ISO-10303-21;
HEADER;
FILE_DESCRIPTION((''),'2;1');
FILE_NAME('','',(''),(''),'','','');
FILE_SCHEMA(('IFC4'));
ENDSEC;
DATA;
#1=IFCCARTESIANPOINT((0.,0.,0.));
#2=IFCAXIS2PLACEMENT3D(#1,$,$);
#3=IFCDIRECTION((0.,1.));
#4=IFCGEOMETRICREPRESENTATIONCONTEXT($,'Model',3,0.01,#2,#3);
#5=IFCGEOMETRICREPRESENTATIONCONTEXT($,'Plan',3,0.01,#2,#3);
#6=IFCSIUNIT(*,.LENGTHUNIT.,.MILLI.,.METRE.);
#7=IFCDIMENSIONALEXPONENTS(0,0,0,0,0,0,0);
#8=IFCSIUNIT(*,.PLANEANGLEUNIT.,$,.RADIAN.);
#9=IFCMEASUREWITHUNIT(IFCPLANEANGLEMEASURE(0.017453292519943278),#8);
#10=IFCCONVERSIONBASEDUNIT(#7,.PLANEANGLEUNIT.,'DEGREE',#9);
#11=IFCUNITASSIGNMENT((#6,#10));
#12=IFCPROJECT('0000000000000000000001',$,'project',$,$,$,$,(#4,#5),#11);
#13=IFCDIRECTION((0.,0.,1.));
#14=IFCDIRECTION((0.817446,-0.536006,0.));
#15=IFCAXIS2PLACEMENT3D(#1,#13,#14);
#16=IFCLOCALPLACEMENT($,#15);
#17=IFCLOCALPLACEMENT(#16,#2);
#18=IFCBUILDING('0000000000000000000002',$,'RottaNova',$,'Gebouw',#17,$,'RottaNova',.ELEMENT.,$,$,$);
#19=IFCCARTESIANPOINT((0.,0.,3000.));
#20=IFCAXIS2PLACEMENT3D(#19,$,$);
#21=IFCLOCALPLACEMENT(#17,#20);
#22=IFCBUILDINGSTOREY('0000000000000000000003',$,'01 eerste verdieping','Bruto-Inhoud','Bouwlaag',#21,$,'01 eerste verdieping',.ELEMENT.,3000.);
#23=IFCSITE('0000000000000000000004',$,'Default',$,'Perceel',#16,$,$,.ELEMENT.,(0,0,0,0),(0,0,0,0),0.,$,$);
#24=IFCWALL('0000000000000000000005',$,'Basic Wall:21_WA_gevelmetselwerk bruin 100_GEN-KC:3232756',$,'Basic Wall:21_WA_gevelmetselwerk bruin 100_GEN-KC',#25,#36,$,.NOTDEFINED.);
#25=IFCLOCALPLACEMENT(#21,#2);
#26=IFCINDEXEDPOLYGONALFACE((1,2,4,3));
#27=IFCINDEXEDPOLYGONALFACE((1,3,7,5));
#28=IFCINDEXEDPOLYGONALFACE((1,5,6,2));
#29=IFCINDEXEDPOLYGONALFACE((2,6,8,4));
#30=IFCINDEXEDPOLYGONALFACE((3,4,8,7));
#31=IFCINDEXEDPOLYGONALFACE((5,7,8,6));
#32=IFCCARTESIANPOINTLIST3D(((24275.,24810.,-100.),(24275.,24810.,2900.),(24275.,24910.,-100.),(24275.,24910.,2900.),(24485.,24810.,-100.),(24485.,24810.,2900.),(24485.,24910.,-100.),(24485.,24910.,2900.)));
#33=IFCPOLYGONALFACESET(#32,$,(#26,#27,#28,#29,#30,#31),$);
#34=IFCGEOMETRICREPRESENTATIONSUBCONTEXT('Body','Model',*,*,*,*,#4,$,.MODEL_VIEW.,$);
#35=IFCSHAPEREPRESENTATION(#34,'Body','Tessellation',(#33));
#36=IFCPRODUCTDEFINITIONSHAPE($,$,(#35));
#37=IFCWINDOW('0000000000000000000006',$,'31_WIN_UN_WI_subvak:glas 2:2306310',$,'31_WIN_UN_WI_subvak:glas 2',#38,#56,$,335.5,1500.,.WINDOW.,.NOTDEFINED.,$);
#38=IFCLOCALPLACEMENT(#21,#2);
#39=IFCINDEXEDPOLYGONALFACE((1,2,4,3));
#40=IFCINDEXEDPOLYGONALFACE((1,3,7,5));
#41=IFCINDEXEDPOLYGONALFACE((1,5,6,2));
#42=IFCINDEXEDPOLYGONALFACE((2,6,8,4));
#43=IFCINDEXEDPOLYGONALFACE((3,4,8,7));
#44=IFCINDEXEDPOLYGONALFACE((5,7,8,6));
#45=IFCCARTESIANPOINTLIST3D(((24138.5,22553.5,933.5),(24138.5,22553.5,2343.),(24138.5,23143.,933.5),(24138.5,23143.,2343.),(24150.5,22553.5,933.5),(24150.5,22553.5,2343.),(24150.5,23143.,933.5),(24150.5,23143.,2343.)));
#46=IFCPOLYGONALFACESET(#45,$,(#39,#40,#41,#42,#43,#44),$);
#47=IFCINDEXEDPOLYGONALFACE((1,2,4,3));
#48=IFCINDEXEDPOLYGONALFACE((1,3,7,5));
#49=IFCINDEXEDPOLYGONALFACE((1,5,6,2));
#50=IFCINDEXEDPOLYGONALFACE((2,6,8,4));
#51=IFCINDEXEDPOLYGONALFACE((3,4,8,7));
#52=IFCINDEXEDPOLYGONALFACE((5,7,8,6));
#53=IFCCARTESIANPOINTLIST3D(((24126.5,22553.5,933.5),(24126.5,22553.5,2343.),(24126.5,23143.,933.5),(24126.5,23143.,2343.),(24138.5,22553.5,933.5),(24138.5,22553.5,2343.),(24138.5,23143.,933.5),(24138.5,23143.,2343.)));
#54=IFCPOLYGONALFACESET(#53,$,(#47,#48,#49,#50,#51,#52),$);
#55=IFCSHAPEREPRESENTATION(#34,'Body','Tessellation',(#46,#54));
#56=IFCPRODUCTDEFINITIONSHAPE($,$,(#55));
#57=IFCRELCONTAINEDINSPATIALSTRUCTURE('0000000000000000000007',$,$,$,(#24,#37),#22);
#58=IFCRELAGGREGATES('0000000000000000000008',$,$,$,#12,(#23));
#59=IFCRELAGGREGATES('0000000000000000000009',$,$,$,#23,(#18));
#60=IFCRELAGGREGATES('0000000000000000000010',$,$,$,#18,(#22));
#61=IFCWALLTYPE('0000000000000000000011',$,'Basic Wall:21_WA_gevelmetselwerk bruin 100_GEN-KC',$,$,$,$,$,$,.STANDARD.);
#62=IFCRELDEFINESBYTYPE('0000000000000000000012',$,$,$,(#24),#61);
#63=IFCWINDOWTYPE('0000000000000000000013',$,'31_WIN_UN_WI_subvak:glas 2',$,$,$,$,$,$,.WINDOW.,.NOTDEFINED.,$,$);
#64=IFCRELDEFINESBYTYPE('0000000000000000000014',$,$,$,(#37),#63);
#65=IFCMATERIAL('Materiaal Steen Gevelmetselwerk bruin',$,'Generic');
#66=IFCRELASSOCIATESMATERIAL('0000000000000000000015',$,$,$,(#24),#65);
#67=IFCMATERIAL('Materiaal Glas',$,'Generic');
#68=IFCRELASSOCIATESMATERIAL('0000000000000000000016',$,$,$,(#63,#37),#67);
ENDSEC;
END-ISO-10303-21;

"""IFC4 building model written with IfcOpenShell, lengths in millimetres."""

from ifc_helpers import new_model, entity, si_unit, converted_unit, direction, frame, origin, place, context, subcontext, project, spatial, indexed_curve, outline, extrude, source, transform, mapped, material, type_object, type_shapes, element, save


model = new_model("IFC4")

# Units and contexts
model_context = context("Model", 3, precision=0.01, world=origin(), true_north=direction((0.0, 1.0)))
plan_context = context("Plan", 3, precision=0.01, world=origin(), true_north=direction((0.0, 1.0)))
body_context = subcontext(model_context, "Body", "Model", "MODEL_VIEW")
ifc_project = project(units=[si_unit("LENGTHUNIT", "METRE", prefix="MILLI"), converted_unit("PLANEANGLEUNIT", "DEGREE", entity("IfcPlaneAngleMeasure", 0.017453292519943278), si_unit("PLANEANGLEUNIT", "RADIAN"), dimensions=[0, 0, 0, 0, 0, 0, 0])], contexts=[model_context, plan_context])

# Site, building, storey
site_placement = place(None, frame((0.0, 0.0, 0.0), z_axis=(0.0, 0.0, 1.0), x_axis=(0.817446, -0.536006, 0.0)))
site = spatial("IfcSite", under=ifc_project, at=site_placement, Name="Default", ObjectType="Perceel", CompositionType="ELEMENT", RefLatitude=(0, 0, 0, 0), RefLongitude=(0, 0, 0, 0), RefElevation=0.0)
building_placement = place(site_placement, origin())
building = spatial("IfcBuilding", under=site, at=building_placement, Name="RottaNova", ObjectType="Gebouw", LongName="RottaNova", CompositionType="ELEMENT")
storey_placement = place(building_placement, frame((0.0, 0.0, 3000.0)))
storey = spatial("IfcBuildingStorey", under=building, at=storey_placement, Name="01 eerste verdieping", Description="Bruto-Inhoud", ObjectType="Bouwlaag", LongName="01 eerste verdieping", CompositionType="ELEMENT", Elevation=3000.0)

# Shared definitions
ifc_material_1 = material(Name="Materiaal Glas", Category="Generic")

# Wall
ifc_material_2 = material(Name="Materiaal Steen Gevelmetselwerk bruin", Category="Generic")
wall_type_1 = type_object("IfcWallType", Name="Basic Wall:21_WA_gevelmetselwerk bruin 100_GEN-KC", PredefinedType="STANDARD")
wall_1_placement = place(storey_placement, frame((24485.0, 24860.0, -100.0), z_axis=(0.0, 0.0, 1.0), x_axis=(-1.0, 0.0, 0.0)))
element("IfcWall", 1, at=wall_1_placement, inside=storey, type_object=wall_type_1, material=ifc_material_2, Name="Basic Wall:21_WA_gevelmetselwerk bruin 100_GEN-KC:3232756", ObjectType="Basic Wall:21_WA_gevelmetselwerk bruin 100_GEN-KC", PredefinedType="NOTDEFINED", context=body_context, shape_type="SweptSolid", body=[
    extrude(outline(indexed_curve([(210.0, 50.0), (0.0, 50.0), (0.0, -50.0), (210.0, -50.0), (210.0, 50.0)], self_intersect=False)), origin(), (0.0, 0.0, 1.0), 3000.0),
])

# Window
window_type = type_object("IfcWindowType", Name="31_WIN_UN_WI_subvak:glas 2", PartitioningType="NOTDEFINED", PredefinedType="WINDOW", material=ifc_material_1)
shared_shape_1 = source(origin(), body_context, "Body", "SweptSolid", [
    extrude(outline(indexed_curve([(-294.7, -6.0), (294.7, -6.0), (294.7, 6.0), (-294.7, 6.0), (-294.7, -6.0)], self_intersect=False)), frame((0.0, -6.0, 0.0)), (0.0, 0.0, 1.0), 1409.5),
    extrude(outline(indexed_curve([(-294.8, -6.0), (294.8, -6.0), (294.8, 6.0), (-294.8, 6.0), (-294.8, -6.0)], self_intersect=False)), frame((0.0, 6.0, 0.0)), (0.0, 0.0, 1.0), 1409.5),
])
type_shapes(window_type, [shared_shape_1])
window_1_placement = place(storey_placement, frame((24138.5, 22848.2, 933.5), z_axis=(0.0, 0.0, 1.0), x_axis=(0.0, 1.0, 0.0)))
element("IfcWindow", 2, at=window_1_placement, inside=storey, type_object=window_type, material=ifc_material_1, Name="31_WIN_UN_WI_subvak:glas 2:2306310", ObjectType="31_WIN_UN_WI_subvak:glas 2", OverallHeight=335.5, OverallWidth=1500.0, PartitioningType="NOTDEFINED", PredefinedType="WINDOW", context=body_context, shape_type="MappedRepresentation", body=[
    mapped(shared_shape_1, transform((0.0, 0.0, 0.0), scale=1.0)),
])

save(model, "model.ifc")
